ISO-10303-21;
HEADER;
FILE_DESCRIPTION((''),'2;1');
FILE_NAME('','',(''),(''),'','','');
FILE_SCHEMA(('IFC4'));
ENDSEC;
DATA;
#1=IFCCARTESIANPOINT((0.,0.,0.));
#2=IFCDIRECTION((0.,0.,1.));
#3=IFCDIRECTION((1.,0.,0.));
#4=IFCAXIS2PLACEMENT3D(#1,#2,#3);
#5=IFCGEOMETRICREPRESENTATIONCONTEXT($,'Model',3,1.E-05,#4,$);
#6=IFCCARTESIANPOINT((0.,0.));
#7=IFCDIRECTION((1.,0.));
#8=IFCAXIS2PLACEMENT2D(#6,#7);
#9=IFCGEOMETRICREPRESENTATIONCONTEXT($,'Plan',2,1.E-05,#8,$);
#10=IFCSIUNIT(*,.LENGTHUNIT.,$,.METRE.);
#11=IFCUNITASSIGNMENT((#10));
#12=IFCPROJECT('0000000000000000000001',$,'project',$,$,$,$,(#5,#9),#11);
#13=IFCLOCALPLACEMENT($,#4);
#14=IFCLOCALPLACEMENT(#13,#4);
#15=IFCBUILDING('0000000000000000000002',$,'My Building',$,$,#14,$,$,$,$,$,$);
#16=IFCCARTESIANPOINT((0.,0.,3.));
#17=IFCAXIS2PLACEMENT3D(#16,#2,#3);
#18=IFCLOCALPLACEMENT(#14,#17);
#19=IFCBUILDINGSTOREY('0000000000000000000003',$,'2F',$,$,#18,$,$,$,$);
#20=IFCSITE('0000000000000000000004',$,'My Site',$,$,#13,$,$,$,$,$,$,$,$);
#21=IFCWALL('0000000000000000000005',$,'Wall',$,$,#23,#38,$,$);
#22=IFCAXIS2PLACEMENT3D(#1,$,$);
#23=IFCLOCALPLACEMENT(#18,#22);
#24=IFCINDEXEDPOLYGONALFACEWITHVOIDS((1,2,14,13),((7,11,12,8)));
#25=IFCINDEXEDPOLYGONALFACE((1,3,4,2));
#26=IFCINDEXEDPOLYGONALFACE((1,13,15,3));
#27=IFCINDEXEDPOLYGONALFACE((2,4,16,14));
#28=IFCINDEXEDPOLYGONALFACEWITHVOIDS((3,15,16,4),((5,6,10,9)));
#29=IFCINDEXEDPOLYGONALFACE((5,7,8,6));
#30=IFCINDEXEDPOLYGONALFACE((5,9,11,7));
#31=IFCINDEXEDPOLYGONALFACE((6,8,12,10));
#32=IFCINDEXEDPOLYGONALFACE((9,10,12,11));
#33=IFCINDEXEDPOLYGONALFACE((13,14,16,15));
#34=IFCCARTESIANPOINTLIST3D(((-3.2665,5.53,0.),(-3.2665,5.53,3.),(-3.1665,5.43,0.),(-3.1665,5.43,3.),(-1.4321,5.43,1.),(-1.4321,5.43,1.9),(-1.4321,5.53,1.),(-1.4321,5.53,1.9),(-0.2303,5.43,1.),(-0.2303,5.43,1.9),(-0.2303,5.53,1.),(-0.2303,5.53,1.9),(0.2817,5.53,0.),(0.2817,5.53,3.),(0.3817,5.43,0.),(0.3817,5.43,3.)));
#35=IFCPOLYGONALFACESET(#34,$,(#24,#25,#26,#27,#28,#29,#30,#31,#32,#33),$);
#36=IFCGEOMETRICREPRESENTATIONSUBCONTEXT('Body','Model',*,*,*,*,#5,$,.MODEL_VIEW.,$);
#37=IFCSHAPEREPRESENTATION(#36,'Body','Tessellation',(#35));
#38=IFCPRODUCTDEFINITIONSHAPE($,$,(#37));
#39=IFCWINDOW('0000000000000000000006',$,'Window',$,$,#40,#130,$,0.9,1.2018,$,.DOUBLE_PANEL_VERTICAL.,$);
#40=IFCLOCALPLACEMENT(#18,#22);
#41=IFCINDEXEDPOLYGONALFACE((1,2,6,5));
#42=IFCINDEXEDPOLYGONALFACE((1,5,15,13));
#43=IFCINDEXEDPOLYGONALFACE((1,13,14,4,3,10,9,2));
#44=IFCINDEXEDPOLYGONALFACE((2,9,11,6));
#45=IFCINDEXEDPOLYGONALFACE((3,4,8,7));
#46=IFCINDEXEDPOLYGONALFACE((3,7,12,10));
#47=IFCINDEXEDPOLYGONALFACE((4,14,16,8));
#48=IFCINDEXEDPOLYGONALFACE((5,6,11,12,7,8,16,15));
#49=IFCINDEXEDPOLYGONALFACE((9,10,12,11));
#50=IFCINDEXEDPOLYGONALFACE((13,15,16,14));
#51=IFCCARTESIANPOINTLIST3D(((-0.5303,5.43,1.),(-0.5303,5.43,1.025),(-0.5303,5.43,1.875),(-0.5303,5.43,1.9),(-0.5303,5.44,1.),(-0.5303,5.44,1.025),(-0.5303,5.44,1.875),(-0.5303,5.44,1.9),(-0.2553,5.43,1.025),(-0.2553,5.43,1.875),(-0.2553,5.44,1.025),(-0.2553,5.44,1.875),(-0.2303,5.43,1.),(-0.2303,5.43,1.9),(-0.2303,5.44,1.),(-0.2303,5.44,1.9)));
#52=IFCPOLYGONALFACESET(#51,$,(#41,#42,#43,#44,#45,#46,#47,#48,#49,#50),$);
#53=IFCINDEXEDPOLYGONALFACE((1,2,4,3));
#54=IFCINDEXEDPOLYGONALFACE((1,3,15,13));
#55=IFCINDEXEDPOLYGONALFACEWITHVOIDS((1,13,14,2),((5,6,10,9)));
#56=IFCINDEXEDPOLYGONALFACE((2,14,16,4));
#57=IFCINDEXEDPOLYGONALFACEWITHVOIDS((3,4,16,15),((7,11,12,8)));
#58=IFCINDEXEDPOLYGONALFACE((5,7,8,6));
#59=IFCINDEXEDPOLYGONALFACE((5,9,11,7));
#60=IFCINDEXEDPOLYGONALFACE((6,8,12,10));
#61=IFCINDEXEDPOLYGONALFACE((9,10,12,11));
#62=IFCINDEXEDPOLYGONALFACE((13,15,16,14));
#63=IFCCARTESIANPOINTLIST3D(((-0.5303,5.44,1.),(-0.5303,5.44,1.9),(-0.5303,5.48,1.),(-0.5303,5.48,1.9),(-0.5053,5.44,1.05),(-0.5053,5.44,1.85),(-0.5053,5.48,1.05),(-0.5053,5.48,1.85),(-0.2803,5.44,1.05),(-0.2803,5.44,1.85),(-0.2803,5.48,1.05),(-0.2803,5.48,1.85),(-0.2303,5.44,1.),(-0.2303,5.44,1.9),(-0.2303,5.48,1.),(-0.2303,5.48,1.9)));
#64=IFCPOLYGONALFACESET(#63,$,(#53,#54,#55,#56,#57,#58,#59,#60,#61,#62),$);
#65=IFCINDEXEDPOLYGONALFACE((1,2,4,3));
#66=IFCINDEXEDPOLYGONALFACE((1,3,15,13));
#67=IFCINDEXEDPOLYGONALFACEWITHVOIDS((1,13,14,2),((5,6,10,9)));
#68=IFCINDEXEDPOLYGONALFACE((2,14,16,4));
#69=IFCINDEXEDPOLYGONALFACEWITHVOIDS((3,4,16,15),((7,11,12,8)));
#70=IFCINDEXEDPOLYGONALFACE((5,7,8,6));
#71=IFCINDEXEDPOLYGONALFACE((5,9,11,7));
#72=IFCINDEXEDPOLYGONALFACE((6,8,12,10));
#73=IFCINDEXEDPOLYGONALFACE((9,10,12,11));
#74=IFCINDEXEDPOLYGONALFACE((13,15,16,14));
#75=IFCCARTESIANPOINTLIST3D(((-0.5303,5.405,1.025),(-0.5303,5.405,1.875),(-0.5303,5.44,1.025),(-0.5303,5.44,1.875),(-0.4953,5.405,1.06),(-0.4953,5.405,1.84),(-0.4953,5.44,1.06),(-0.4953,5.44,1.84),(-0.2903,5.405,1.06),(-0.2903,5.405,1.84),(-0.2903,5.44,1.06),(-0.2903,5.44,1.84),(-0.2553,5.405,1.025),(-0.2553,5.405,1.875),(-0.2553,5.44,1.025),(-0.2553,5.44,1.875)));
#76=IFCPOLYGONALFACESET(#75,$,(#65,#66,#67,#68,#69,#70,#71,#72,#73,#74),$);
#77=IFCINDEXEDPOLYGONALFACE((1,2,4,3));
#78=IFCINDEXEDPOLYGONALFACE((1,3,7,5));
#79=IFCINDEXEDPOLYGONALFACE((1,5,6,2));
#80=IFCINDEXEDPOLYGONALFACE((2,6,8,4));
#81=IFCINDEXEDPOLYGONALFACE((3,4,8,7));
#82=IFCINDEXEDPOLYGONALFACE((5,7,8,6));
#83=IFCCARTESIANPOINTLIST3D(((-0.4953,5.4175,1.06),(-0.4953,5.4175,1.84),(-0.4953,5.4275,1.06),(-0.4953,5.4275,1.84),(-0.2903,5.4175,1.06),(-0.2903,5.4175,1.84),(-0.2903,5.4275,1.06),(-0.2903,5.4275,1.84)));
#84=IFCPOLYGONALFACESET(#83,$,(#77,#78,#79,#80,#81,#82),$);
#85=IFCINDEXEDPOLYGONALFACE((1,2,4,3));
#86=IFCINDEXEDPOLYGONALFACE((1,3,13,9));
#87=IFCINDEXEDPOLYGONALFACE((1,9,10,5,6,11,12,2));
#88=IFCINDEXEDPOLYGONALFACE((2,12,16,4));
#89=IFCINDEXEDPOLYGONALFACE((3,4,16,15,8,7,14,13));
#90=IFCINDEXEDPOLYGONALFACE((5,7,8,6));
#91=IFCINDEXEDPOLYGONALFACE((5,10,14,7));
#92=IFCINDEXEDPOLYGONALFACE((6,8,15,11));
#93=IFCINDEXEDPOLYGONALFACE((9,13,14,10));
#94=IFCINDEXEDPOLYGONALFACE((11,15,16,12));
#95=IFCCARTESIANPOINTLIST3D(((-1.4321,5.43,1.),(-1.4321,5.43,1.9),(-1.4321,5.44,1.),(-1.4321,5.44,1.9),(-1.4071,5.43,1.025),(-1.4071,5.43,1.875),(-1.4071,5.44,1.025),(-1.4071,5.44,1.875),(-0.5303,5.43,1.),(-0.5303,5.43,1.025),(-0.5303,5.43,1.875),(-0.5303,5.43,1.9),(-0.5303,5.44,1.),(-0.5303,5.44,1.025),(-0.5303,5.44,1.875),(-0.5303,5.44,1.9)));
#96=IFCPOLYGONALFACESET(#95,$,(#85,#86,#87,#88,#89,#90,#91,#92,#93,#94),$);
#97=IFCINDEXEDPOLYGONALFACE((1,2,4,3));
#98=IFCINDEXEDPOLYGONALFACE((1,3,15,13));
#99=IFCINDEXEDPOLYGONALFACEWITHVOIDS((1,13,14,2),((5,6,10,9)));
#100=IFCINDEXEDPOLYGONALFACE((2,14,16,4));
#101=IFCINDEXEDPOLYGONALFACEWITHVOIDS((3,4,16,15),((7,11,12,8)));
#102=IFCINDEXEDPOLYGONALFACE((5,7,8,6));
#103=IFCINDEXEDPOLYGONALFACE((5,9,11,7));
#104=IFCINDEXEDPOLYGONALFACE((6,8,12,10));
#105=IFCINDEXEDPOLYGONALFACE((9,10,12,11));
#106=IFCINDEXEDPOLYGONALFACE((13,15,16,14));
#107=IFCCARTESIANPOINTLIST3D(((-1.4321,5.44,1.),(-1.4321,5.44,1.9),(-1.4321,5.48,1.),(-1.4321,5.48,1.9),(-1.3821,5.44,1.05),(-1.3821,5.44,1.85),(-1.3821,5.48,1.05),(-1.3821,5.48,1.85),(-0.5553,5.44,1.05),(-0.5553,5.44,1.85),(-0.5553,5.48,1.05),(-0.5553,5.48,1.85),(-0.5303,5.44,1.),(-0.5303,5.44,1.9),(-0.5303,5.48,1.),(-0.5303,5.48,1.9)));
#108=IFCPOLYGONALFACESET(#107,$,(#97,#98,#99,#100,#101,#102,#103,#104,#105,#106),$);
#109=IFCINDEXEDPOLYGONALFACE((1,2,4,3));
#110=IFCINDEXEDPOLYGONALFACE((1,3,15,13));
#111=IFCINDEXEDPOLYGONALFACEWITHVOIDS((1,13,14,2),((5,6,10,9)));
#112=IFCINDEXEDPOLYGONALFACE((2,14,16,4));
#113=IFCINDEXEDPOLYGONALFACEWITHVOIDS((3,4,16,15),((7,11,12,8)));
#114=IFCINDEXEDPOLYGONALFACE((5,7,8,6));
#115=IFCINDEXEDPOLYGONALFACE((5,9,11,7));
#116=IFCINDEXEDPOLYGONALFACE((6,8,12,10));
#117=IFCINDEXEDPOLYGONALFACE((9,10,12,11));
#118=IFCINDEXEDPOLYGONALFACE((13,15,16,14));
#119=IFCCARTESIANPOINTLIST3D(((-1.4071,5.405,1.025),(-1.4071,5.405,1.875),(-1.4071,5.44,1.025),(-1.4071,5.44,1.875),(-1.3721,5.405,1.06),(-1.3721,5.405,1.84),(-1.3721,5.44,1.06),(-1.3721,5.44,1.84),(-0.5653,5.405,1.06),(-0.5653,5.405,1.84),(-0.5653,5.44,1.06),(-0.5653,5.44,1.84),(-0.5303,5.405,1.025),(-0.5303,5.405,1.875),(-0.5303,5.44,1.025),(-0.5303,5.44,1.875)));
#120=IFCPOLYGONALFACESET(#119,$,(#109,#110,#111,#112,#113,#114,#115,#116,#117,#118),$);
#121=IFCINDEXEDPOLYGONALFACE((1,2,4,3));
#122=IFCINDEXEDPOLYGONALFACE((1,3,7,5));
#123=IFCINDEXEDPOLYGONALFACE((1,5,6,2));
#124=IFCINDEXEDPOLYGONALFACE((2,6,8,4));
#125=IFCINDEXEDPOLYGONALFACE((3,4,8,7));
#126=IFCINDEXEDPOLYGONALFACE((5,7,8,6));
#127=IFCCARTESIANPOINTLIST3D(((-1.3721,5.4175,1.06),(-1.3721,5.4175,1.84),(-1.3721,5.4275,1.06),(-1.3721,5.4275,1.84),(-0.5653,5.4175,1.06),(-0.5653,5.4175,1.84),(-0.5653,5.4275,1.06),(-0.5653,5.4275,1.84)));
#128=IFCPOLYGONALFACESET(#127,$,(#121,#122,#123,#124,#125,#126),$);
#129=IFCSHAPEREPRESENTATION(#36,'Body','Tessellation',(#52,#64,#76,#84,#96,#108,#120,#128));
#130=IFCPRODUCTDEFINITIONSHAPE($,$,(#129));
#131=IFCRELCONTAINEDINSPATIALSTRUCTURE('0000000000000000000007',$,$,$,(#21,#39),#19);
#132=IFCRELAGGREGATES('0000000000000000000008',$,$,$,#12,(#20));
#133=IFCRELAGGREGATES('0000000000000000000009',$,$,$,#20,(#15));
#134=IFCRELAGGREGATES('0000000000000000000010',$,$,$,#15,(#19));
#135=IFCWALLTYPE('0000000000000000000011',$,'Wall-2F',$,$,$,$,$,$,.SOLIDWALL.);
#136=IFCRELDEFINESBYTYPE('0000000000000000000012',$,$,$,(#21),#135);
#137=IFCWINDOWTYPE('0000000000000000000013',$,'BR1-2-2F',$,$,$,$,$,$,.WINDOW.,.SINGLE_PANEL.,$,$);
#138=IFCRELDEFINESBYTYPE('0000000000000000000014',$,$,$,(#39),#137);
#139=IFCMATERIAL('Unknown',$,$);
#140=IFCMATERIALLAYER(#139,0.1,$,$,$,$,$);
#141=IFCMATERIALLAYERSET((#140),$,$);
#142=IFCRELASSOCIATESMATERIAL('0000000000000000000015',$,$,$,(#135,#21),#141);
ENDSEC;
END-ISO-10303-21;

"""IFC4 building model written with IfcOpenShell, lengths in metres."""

from ifc_helpers import new_model, entity, si_unit, frame, origin_with_axes, origin_2d_with_axis, place, context, subcontext, project, spatial, line, indexed_curve, outline, extrude, shape, source, transform, mapped, material, layer, layer_set, layer_usage, type_object, type_shapes, element, fill, save


model = new_model("IFC4")

# Units and contexts
model_context = context("Model", 3, precision=1e-05, world=origin_with_axes())
plan_context = context("Plan", 2, precision=1e-05, world=origin_2d_with_axis())
body_context_1 = subcontext(model_context, "Body", "Model", "MODEL_VIEW")
body_context_2 = subcontext(plan_context, "Body", "Plan", "PLAN_VIEW")
ifc_project = project(units=[si_unit("LENGTHUNIT", "METRE")], contexts=[model_context, plan_context])

# Site, building, storey
site_placement = place(None, origin_with_axes())
site = spatial("IfcSite", under=ifc_project, at=site_placement, Name="My Site")
building_placement = place(site_placement, origin_with_axes())
building = spatial("IfcBuilding", under=site, at=building_placement, Name="My Building")
storey_placement = place(building_placement, frame((0.0, 0.0, 3.0), z_axis=(0.0, 0.0, 1.0), x_axis=(1.0, 0.0, 0.0)))
storey = spatial("IfcBuildingStorey", under=building, at=storey_placement, Name="2F")

# Shared definitions
ifc_material = material(Name="Unknown")

# Shared definitions
ifc_layer_1 = layer(ifc_material, 0.1)
ifc_layer_set_1 = layer_set([ifc_layer_1])
wall_type_1 = type_object("IfcWallType", Name="Wall-2F", PredefinedType="SOLIDWALL", material=ifc_layer_set_1)

# Wall, opening, window
ifc_layer_usage_1 = layer_usage(ifc_layer_set_1, "AXIS2", "POSITIVE", 0.0)
wall_1_placement = place(storey_placement, frame((0.2817, 5.53, 0.0), z_axis=(0.0, 0.0, 1.0), x_axis=(-1.0, 0.0, 0.0)))
wall_1 = element("IfcWall", 1, at=wall_1_placement, inside=storey, type_object=wall_type_1, material=ifc_layer_usage_1, Name="Wall", context=body_context_1, shape_type="SweptSolid", body=[
    extrude(outline(indexed_curve([(0.0, 0.0), (-0.1, 0.1), (3.4482, 0.1), (3.5482, 0.0)], segments=[line(1, 2, 3, 4, 1)])), origin_with_axes(), (0.0, 0.0, 1.0), 3.0),
])
shared_shape_1 = source(origin_with_axes(), body_context_1, "Body", "SweptSolid", [
    extrude(outline(indexed_curve([(0.0, 0.0), (1.2018, 0.0), (1.2018, 0.9), (0.0, 0.9)], segments=[line(1, 2, 3, 4, 1)])), frame((0.0, -0.6, 0.0), z_axis=(0.0, -1.0, 0.0), x_axis=(1.0, 0.0, 0.0)), (0.0, 0.0, -1.0), 1.2),
])
opening_1_placement = place(wall_1_placement, frame((0.512, 0.0, 1.0), z_axis=(0.0, 0.0, 1.0), x_axis=(1.0, 0.0, 0.0)))
opening_1 = element("IfcOpeningElement", 2, at=opening_1_placement, cuts=wall_1, PredefinedType="OPENING", context=body_context_1, shape_type="MappedRepresentation", body=[
    mapped(shared_shape_1, transform((0.0, 0.0, 0.0), x_axis=(1.0, 0.0, 0.0), y_axis=(0.0, 1.0, 0.0), z_axis=(0.0, 0.0, 1.0), scale=1.0)),
])
window_type_1 = type_object("IfcWindowType", Name="BR1-2-2F", PartitioningType="SINGLE_PANEL", PredefinedType="WINDOW")
shared_shape_2 = source(origin_with_axes(), body_context_1, "Body", "SweptSolid", [
    extrude(outline(indexed_curve([(0.3, 0.0), (0.0, 0.0), (0.0, 0.9), (0.3, 0.9), (0.3, 0.875), (0.025, 0.875), (0.025, 0.025), (0.3, 0.025)], segments=[line(1, 2, 3, 4, 5, 6, 7, 8, 1)])), frame((0.0, 0.09, 0.0), z_axis=(0.0, -1.0, 0.0), x_axis=(1.0, 0.0, 0.0)), (0.0, 0.0, -1.0), 0.01),
    extrude(outline(indexed_curve([(0.0, 0.0), (0.3, 0.0), (0.3, 0.9), (0.0, 0.9)], segments=[line(1, 2, 3, 4, 1)]), holes=[indexed_curve([(0.05, 0.05), (0.275, 0.05), (0.275, 0.85), (0.05, 0.85)], segments=[line(1, 2, 3, 4, 1)])]), frame((0.0, 0.05, 0.0), z_axis=(0.0, -1.0, 0.0), x_axis=(1.0, 0.0, 0.0)), (0.0, 0.0, -1.0), 0.04),
    extrude(outline(indexed_curve([(0.0, 0.0), (0.275, 0.0), (0.275, 0.85), (0.0, 0.85)], segments=[line(1, 2, 3, 4, 1)]), holes=[indexed_curve([(0.035, 0.035), (0.24, 0.035), (0.24, 0.815), (0.035, 0.815)], segments=[line(1, 2, 3, 4, 1)])]), frame((0.025, 0.09, 0.025), z_axis=(0.0, -1.0, 0.0), x_axis=(1.0, 0.0, 0.0)), (0.0, 0.0, -1.0), 0.035),
    extrude(outline(indexed_curve([(0.035, 0.035), (0.24, 0.035), (0.24, 0.815), (0.035, 0.815)], segments=[line(1, 2, 3, 4, 1)])), frame((0.025, 0.1025, 0.025), z_axis=(0.0, -1.0, 0.0), x_axis=(1.0, 0.0, 0.0)), (0.0, 0.0, -1.0), 0.01),
    extrude(outline(indexed_curve([(0.0, 0.9), (0.9018, 0.9), (0.9018, 0.0), (0.0, 0.0), (0.0, 0.025), (0.8768, 0.025), (0.8768, 0.875), (0.0, 0.875)], segments=[line(1, 2, 3, 4, 5, 6, 7, 8, 1)])), frame((0.3, 0.09, 0.0), z_axis=(0.0, -1.0, 0.0), x_axis=(1.0, 0.0, 0.0)), (0.0, 0.0, -1.0), 0.01),
    extrude(outline(indexed_curve([(0.0, 0.0), (0.9018, 0.0), (0.9018, 0.9), (0.0, 0.9)], segments=[line(1, 2, 3, 4, 1)]), holes=[indexed_curve([(0.025, 0.05), (0.8518, 0.05), (0.8518, 0.85), (0.025, 0.85)], segments=[line(1, 2, 3, 4, 1)])]), frame((0.3, 0.05, 0.0), z_axis=(0.0, -1.0, 0.0), x_axis=(1.0, 0.0, 0.0)), (0.0, 0.0, -1.0), 0.04),
    extrude(outline(indexed_curve([(0.0, 0.0), (0.8768, 0.0), (0.8768, 0.85), (0.0, 0.85)], segments=[line(1, 2, 3, 4, 1)]), holes=[indexed_curve([(0.035, 0.035), (0.8418, 0.035), (0.8418, 0.815), (0.035, 0.815)], segments=[line(1, 2, 3, 4, 1)])]), frame((0.3, 0.09, 0.025), z_axis=(0.0, -1.0, 0.0), x_axis=(1.0, 0.0, 0.0)), (0.0, 0.0, -1.0), 0.035),
    extrude(outline(indexed_curve([(0.035, 0.035), (0.8418, 0.035), (0.8418, 0.815), (0.035, 0.815)], segments=[line(1, 2, 3, 4, 1)])), frame((0.3, 0.1025, 0.025), z_axis=(0.0, -1.0, 0.0), x_axis=(1.0, 0.0, 0.0)), (0.0, 0.0, -1.0), 0.01),
])
shared_shape_3 = source(origin_with_axes(), body_context_2, "Body", "Curve2D", [
    entity("IfcIndexedPolyCurve", entity("IfcCartesianPointList2D", [[0.05, 0.05], [0.275, 0.05]])),
    entity("IfcIndexedPolyCurve", entity("IfcCartesianPointList2D", [[0.0, 0.1], [0.025, 0.1], [0.025, 0.09], [0.05, 0.09], [0.05, 0.05], [0.0, 0.05]]), [entity("IfcLineIndex", [1, 2, 3, 4, 5, 6, 1])]),
    entity("IfcIndexedPolyCurve", entity("IfcCartesianPointList2D", [[0.3, 0.1], [0.3, 0.1], [0.3, 0.09], [0.275, 0.09], [0.275, 0.05], [0.3, 0.05]])),
    entity("IfcIndexedPolyCurve", entity("IfcCartesianPointList2D", [[0.025, 0.09], [0.06, 0.09], [0.06, 0.125], [0.025, 0.125]]), [entity("IfcLineIndex", [1, 2, 3, 4, 1])]),
    entity("IfcIndexedPolyCurve", entity("IfcCartesianPointList2D", [[0.3, 0.09], [0.265, 0.09], [0.265, 0.125], [0.3, 0.125]]), [entity("IfcLineIndex", [1, 2, 3, 4, 1])]),
    entity("IfcIndexedPolyCurve", entity("IfcCartesianPointList2D", [[0.06, 0.09], [0.265, 0.09]])),
    entity("IfcIndexedPolyCurve", entity("IfcCartesianPointList2D", [[0.06, 0.125], [0.265, 0.125]])),
    entity("IfcIndexedPolyCurve", entity("IfcCartesianPointList2D", [[0.06, 0.1075], [0.265, 0.1075]])),
    entity("IfcIndexedPolyCurve", entity("IfcCartesianPointList2D", [[0.325, 0.05], [1.1518, 0.05]])),
    entity("IfcIndexedPolyCurve", entity("IfcCartesianPointList2D", [[0.3, 0.1], [0.3, 0.1], [0.3, 0.09], [0.325, 0.09], [0.325, 0.05], [0.3, 0.05]])),
    entity("IfcIndexedPolyCurve", entity("IfcCartesianPointList2D", [[1.2018, 0.1], [1.1768, 0.1], [1.1768, 0.09], [1.1518, 0.09], [1.1518, 0.05], [1.2018, 0.05]]), [entity("IfcLineIndex", [1, 2, 3, 4, 5, 6, 1])]),
    entity("IfcIndexedPolyCurve", entity("IfcCartesianPointList2D", [[0.3, 0.09], [0.335, 0.09], [0.335, 0.125], [0.3, 0.125]]), [entity("IfcLineIndex", [1, 2, 3, 4, 1])]),
    entity("IfcIndexedPolyCurve", entity("IfcCartesianPointList2D", [[1.1768, 0.09], [1.1418, 0.09], [1.1418, 0.125], [1.1768, 0.125]]), [entity("IfcLineIndex", [1, 2, 3, 4, 1])]),
    entity("IfcIndexedPolyCurve", entity("IfcCartesianPointList2D", [[0.335, 0.09], [1.1418, 0.09]])),
    entity("IfcIndexedPolyCurve", entity("IfcCartesianPointList2D", [[0.335, 0.125], [1.1418, 0.125]])),
    entity("IfcIndexedPolyCurve", entity("IfcCartesianPointList2D", [[0.335, 0.1075], [1.1418, 0.1075]])),
])
type_shapes(window_type_1, [shared_shape_2, shared_shape_3])
window_1_placement = place(opening_1_placement, origin_with_axes())
window_1 = element("IfcWindow", 3, at=window_1_placement, inside=storey, type_object=window_type_1, Name="Window", OverallHeight=0.9, OverallWidth=1.2018, PartitioningType="DOUBLE_PANEL_VERTICAL", shapes=[
    shape(body_context_1, "Body", "MappedRepresentation", [mapped(shared_shape_2, transform((0.0, 0.0, 0.0), x_axis=(1.0, 0.0, 0.0), y_axis=(0.0, 1.0, 0.0), z_axis=(0.0, 0.0, 1.0), scale=1.0))]),
    shape(body_context_2, "Body", "MappedRepresentation", [mapped(shared_shape_3, transform((0.0, 0.0, 0.0), x_axis=(1.0, 0.0, 0.0), y_axis=(0.0, 1.0, 0.0), z_axis=(0.0, 0.0, 1.0), scale=1.0))]),
])
fill(opening_1, window_1)

save(model, "model.ifc")
